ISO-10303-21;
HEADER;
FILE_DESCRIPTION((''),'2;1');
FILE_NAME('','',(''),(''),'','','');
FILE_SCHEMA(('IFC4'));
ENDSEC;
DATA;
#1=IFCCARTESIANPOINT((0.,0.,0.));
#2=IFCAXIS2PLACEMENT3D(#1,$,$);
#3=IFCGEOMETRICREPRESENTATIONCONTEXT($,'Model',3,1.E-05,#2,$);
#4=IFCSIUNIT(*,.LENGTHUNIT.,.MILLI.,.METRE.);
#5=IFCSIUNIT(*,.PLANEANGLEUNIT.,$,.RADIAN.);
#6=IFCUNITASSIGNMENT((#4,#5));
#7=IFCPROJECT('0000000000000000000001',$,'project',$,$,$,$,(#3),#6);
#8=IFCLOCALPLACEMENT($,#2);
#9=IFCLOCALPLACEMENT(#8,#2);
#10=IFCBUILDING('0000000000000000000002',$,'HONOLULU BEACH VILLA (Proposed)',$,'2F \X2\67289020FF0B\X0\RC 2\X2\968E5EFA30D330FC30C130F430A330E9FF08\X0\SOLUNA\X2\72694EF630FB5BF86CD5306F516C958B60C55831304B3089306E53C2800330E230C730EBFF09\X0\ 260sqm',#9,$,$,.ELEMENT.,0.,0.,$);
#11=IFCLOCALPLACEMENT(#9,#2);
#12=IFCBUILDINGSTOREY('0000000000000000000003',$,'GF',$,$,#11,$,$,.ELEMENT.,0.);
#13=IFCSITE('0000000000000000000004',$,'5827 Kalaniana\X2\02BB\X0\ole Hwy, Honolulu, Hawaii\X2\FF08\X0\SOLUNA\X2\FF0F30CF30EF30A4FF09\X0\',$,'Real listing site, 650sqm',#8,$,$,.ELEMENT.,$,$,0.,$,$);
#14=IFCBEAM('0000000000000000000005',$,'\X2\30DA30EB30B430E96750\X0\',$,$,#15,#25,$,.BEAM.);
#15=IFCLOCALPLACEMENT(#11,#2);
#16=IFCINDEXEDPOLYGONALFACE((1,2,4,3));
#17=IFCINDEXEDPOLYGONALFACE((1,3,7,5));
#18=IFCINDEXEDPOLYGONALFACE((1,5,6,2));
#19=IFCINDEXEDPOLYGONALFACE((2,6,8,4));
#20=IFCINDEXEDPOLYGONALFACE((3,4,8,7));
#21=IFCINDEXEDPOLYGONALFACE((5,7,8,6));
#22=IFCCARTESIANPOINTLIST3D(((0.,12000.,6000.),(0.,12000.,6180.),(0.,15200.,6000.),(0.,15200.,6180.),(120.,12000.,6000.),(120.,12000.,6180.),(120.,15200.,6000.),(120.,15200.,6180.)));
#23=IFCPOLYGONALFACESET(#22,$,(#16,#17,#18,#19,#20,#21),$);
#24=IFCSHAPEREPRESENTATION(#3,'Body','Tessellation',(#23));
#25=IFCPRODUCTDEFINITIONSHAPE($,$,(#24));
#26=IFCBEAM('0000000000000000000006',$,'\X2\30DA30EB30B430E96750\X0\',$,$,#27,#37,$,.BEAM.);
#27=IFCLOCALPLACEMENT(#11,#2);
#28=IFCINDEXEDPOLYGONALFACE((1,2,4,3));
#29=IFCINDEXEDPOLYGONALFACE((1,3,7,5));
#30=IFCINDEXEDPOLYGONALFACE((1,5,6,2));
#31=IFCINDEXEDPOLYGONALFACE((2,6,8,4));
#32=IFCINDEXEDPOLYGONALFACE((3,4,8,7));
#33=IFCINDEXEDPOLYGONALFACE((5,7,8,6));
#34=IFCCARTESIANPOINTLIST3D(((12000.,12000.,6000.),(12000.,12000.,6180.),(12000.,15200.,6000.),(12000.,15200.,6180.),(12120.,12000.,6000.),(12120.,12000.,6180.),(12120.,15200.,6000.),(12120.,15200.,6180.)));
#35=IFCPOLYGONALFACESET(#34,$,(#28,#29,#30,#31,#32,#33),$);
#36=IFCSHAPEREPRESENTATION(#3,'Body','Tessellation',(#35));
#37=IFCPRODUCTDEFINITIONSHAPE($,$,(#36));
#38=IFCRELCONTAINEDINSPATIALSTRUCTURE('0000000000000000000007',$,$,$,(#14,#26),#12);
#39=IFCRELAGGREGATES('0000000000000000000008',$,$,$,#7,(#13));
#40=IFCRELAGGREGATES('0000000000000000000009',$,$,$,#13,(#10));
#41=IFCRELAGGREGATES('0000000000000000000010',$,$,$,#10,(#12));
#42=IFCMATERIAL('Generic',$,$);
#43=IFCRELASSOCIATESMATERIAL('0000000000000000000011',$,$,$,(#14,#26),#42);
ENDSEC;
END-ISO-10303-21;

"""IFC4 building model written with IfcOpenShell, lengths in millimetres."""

from ifc_helpers import new_model, si_unit, frame, frame_2d, origin, place, context, project, spatial, rectangle, extrude, material, element, save


model = new_model("IFC4")

# Units and contexts
model_context = context("Model", 3, precision=1e-05, world=origin())
ifc_project = project(units=[si_unit("LENGTHUNIT", "METRE", prefix="MILLI"), si_unit("PLANEANGLEUNIT", "RADIAN")], contexts=[model_context])

# Site, building, storey
site_placement = place(None, origin())
site = spatial("IfcSite", under=ifc_project, at=site_placement, Name="5827 Kalanianaʻole Hwy, Honolulu, Hawaii（SOLUNA／ハワイ）", ObjectType="Real listing site, 650sqm", CompositionType="ELEMENT", RefElevation=0.0)
building_placement = place(site_placement, origin())
building = spatial("IfcBuilding", under=site, at=building_placement, Name="HONOLULU BEACH VILLA (Proposed)", ObjectType="2F 木造＋RC 2階建ビーチヴィラ（SOLUNA物件・寸法は公開情報からの参考モデル） 260sqm", CompositionType="ELEMENT", ElevationOfRefHeight=0.0, ElevationOfTerrain=0.0)
storey_placement = place(building_placement, origin())
storey = spatial("IfcBuildingStorey", under=building, at=storey_placement, Name="GF", CompositionType="ELEMENT", Elevation=0.0)

# Shared definitions
ifc_material_1 = material(Name="Generic")

# Beams
beam_1_placement = place(storey_placement, frame((0.0, 6000.0, 3000.0)))
element("IfcBeam", 1, at=beam_1_placement, inside=storey, material=ifc_material_1, Name="ペルゴラ材", PredefinedType="BEAM", context=model_context, shape_type="SweptSolid", body=[
    extrude(rectangle(XDim=120.0, YDim=3200.0, at=frame_2d((60.0, 1600.0))), frame((0.0, 6000.0, 3000.0)), (0.0, 0.0, 1.0), 180.0),
])
beam_2_placement = place(storey_placement, frame((6000.0, 6000.0, 3000.0)))
element("IfcBeam", 2, at=beam_2_placement, inside=storey, material=ifc_material_1, Name="ペルゴラ材", PredefinedType="BEAM", context=model_context, shape_type="SweptSolid", body=[
    extrude(rectangle(XDim=120.0, YDim=3200.0, at=frame_2d((60.0, 1600.0))), frame((6000.0, 6000.0, 3000.0)), (0.0, 0.0, 1.0), 180.0),
])

save(model, "model.ifc")
